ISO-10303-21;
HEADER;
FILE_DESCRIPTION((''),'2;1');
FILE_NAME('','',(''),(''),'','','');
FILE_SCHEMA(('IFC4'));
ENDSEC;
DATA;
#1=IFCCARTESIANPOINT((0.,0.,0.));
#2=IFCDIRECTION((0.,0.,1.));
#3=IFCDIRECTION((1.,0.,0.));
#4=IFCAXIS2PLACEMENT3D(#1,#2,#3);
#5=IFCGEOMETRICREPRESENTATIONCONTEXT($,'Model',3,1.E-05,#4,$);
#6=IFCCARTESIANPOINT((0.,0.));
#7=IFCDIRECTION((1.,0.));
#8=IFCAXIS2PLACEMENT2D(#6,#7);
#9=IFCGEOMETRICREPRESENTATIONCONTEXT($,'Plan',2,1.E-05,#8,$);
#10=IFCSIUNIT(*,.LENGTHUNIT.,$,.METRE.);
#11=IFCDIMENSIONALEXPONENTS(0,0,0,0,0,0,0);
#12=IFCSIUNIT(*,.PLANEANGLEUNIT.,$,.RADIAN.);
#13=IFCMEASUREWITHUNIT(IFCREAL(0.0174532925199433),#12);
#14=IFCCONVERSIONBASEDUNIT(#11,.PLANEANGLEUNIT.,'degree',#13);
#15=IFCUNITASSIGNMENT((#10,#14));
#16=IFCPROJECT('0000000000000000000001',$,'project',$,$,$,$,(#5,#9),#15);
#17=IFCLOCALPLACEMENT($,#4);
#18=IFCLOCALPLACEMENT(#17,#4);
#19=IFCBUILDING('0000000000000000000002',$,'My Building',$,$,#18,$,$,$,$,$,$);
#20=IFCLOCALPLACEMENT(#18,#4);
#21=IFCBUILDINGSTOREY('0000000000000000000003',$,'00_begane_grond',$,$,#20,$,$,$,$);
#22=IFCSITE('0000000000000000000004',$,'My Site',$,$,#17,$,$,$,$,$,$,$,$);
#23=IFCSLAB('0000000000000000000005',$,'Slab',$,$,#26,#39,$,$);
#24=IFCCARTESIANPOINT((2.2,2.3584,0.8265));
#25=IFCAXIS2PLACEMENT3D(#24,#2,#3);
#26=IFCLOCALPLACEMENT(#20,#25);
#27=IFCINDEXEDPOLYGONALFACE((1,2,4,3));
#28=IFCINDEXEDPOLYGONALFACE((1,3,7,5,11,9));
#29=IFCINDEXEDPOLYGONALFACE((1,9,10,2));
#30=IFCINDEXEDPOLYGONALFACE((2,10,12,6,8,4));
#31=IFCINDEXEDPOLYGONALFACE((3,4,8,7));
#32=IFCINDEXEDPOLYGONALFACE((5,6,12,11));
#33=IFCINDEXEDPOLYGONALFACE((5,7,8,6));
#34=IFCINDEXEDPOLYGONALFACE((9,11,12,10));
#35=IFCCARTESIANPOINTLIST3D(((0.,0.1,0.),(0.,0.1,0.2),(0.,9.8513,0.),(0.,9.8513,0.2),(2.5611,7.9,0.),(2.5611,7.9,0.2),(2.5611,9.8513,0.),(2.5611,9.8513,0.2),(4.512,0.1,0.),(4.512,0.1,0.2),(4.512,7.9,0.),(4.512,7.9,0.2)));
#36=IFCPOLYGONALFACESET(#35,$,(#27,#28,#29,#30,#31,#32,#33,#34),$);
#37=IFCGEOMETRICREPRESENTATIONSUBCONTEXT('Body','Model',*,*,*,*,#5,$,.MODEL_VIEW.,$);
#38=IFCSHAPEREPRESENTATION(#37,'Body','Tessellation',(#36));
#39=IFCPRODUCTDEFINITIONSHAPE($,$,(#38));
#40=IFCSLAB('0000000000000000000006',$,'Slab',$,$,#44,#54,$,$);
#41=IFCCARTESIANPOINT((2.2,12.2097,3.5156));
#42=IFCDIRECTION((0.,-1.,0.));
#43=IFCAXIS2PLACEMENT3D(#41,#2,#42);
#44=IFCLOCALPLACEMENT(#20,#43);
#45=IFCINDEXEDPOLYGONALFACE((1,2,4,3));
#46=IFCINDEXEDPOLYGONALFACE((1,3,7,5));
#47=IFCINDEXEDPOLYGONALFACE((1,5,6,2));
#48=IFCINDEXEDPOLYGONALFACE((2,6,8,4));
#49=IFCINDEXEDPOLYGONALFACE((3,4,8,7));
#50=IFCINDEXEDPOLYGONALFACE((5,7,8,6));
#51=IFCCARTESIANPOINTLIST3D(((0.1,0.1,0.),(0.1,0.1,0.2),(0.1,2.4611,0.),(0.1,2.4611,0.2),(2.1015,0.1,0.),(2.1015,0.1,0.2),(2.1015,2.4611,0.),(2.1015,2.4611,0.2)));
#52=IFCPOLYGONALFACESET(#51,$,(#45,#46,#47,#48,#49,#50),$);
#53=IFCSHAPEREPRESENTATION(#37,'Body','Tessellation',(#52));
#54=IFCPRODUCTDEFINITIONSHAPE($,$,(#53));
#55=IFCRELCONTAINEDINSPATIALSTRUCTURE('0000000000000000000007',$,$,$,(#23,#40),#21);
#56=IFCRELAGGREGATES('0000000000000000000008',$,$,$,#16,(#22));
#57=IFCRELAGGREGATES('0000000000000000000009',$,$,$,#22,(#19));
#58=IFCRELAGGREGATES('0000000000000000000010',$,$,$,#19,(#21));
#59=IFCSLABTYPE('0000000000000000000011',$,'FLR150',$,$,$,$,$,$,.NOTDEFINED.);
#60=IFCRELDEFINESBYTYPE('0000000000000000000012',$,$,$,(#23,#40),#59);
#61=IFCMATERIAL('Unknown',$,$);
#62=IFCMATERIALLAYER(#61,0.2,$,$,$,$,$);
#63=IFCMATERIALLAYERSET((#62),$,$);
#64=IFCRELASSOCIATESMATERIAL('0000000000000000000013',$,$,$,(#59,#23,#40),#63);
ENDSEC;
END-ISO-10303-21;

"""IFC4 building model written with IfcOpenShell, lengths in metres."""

from ifc_helpers import new_model, entity, si_unit, converted_unit, frame, origin_with_axes, origin_2d_with_axis, place, context, subcontext, project, spatial, line, indexed_curve, outline, extrude, material, layer, layer_set, layer_usage, type_object, element, save


model = new_model("IFC4")

# Units and contexts
model_context = context("Model", 3, precision=1e-05, world=origin_with_axes())
plan_context = context("Plan", 2, precision=1e-05, world=origin_2d_with_axis())
body_context_1 = subcontext(model_context, "Body", "Model", "MODEL_VIEW")
ifc_project = project(units=[si_unit("LENGTHUNIT", "METRE"), converted_unit("PLANEANGLEUNIT", "degree", entity("IfcReal", 0.0174532925199433), si_unit("PLANEANGLEUNIT", "RADIAN"), dimensions=[0, 0, 0, 0, 0, 0, 0])], contexts=[model_context, plan_context])

# Site, building, storey
site_placement = place(None, origin_with_axes())
site = spatial("IfcSite", under=ifc_project, at=site_placement, Name="My Site")
building_placement = place(site_placement, origin_with_axes())
building = spatial("IfcBuilding", under=site, at=building_placement, Name="My Building")
storey_placement = place(building_placement, origin_with_axes())
storey = spatial("IfcBuildingStorey", under=building, at=storey_placement, Name="00_begane_grond")

# Slabs
ifc_material_1 = material(Name="Unknown")
ifc_layer_1 = layer(ifc_material_1, 0.2)
ifc_layer_set_1 = layer_set([ifc_layer_1])
ifc_layer_usage_1 = layer_usage(ifc_layer_set_1, "AXIS3", "POSITIVE", 0.0)
slab_type = type_object("IfcSlabType", Name="FLR150", PredefinedType="NOTDEFINED", material=ifc_layer_set_1)
slab_1_placement = place(storey_placement, frame((2.2, 2.3584, 0.8265), z_axis=(0.0, 0.0, 1.0), x_axis=(1.0, 0.0, 0.0)))
element("IfcSlab", 1, at=slab_1_placement, inside=storey, type_object=slab_type, material=ifc_layer_usage_1, Name="Slab", context=body_context_1, shape_type="SweptSolid", body=[
    extrude(outline(indexed_curve([(2.5611, 9.8513), (2.5611, 7.9), (4.512, 7.9), (4.512, 0.1), (0.0, 0.1), (0.0, 9.8513)], segments=[line(4, 3), line(3, 2), line(2, 1), line(1, 6), line(6, 5), line(5, 4)], self_intersect=False)), None, (0.0, 0.0, 1.0), 0.2),
])
ifc_layer_usage_2 = layer_usage(ifc_layer_set_1, "AXIS3", "POSITIVE", 0.0)
slab_2_placement = place(storey_placement, frame((2.2, 12.2097, 3.5156), z_axis=(0.0, 0.0, 1.0), x_axis=(0.0, -1.0, 0.0)))
element("IfcSlab", 2, at=slab_2_placement, inside=storey, type_object=slab_type, material=ifc_layer_usage_2, Name="Slab", context=body_context_1, shape_type="SweptSolid", body=[
    extrude(outline(indexed_curve([(2.1015, 0.1), (0.1, 0.1), (0.1, 2.4611), (2.1015, 2.4611)], segments=[line(3, 2), line(2, 1), line(1, 4), line(4, 3)], self_intersect=False)), None, (0.0, 0.0, 1.0), 0.2),
])

save(model, "model.ifc")
